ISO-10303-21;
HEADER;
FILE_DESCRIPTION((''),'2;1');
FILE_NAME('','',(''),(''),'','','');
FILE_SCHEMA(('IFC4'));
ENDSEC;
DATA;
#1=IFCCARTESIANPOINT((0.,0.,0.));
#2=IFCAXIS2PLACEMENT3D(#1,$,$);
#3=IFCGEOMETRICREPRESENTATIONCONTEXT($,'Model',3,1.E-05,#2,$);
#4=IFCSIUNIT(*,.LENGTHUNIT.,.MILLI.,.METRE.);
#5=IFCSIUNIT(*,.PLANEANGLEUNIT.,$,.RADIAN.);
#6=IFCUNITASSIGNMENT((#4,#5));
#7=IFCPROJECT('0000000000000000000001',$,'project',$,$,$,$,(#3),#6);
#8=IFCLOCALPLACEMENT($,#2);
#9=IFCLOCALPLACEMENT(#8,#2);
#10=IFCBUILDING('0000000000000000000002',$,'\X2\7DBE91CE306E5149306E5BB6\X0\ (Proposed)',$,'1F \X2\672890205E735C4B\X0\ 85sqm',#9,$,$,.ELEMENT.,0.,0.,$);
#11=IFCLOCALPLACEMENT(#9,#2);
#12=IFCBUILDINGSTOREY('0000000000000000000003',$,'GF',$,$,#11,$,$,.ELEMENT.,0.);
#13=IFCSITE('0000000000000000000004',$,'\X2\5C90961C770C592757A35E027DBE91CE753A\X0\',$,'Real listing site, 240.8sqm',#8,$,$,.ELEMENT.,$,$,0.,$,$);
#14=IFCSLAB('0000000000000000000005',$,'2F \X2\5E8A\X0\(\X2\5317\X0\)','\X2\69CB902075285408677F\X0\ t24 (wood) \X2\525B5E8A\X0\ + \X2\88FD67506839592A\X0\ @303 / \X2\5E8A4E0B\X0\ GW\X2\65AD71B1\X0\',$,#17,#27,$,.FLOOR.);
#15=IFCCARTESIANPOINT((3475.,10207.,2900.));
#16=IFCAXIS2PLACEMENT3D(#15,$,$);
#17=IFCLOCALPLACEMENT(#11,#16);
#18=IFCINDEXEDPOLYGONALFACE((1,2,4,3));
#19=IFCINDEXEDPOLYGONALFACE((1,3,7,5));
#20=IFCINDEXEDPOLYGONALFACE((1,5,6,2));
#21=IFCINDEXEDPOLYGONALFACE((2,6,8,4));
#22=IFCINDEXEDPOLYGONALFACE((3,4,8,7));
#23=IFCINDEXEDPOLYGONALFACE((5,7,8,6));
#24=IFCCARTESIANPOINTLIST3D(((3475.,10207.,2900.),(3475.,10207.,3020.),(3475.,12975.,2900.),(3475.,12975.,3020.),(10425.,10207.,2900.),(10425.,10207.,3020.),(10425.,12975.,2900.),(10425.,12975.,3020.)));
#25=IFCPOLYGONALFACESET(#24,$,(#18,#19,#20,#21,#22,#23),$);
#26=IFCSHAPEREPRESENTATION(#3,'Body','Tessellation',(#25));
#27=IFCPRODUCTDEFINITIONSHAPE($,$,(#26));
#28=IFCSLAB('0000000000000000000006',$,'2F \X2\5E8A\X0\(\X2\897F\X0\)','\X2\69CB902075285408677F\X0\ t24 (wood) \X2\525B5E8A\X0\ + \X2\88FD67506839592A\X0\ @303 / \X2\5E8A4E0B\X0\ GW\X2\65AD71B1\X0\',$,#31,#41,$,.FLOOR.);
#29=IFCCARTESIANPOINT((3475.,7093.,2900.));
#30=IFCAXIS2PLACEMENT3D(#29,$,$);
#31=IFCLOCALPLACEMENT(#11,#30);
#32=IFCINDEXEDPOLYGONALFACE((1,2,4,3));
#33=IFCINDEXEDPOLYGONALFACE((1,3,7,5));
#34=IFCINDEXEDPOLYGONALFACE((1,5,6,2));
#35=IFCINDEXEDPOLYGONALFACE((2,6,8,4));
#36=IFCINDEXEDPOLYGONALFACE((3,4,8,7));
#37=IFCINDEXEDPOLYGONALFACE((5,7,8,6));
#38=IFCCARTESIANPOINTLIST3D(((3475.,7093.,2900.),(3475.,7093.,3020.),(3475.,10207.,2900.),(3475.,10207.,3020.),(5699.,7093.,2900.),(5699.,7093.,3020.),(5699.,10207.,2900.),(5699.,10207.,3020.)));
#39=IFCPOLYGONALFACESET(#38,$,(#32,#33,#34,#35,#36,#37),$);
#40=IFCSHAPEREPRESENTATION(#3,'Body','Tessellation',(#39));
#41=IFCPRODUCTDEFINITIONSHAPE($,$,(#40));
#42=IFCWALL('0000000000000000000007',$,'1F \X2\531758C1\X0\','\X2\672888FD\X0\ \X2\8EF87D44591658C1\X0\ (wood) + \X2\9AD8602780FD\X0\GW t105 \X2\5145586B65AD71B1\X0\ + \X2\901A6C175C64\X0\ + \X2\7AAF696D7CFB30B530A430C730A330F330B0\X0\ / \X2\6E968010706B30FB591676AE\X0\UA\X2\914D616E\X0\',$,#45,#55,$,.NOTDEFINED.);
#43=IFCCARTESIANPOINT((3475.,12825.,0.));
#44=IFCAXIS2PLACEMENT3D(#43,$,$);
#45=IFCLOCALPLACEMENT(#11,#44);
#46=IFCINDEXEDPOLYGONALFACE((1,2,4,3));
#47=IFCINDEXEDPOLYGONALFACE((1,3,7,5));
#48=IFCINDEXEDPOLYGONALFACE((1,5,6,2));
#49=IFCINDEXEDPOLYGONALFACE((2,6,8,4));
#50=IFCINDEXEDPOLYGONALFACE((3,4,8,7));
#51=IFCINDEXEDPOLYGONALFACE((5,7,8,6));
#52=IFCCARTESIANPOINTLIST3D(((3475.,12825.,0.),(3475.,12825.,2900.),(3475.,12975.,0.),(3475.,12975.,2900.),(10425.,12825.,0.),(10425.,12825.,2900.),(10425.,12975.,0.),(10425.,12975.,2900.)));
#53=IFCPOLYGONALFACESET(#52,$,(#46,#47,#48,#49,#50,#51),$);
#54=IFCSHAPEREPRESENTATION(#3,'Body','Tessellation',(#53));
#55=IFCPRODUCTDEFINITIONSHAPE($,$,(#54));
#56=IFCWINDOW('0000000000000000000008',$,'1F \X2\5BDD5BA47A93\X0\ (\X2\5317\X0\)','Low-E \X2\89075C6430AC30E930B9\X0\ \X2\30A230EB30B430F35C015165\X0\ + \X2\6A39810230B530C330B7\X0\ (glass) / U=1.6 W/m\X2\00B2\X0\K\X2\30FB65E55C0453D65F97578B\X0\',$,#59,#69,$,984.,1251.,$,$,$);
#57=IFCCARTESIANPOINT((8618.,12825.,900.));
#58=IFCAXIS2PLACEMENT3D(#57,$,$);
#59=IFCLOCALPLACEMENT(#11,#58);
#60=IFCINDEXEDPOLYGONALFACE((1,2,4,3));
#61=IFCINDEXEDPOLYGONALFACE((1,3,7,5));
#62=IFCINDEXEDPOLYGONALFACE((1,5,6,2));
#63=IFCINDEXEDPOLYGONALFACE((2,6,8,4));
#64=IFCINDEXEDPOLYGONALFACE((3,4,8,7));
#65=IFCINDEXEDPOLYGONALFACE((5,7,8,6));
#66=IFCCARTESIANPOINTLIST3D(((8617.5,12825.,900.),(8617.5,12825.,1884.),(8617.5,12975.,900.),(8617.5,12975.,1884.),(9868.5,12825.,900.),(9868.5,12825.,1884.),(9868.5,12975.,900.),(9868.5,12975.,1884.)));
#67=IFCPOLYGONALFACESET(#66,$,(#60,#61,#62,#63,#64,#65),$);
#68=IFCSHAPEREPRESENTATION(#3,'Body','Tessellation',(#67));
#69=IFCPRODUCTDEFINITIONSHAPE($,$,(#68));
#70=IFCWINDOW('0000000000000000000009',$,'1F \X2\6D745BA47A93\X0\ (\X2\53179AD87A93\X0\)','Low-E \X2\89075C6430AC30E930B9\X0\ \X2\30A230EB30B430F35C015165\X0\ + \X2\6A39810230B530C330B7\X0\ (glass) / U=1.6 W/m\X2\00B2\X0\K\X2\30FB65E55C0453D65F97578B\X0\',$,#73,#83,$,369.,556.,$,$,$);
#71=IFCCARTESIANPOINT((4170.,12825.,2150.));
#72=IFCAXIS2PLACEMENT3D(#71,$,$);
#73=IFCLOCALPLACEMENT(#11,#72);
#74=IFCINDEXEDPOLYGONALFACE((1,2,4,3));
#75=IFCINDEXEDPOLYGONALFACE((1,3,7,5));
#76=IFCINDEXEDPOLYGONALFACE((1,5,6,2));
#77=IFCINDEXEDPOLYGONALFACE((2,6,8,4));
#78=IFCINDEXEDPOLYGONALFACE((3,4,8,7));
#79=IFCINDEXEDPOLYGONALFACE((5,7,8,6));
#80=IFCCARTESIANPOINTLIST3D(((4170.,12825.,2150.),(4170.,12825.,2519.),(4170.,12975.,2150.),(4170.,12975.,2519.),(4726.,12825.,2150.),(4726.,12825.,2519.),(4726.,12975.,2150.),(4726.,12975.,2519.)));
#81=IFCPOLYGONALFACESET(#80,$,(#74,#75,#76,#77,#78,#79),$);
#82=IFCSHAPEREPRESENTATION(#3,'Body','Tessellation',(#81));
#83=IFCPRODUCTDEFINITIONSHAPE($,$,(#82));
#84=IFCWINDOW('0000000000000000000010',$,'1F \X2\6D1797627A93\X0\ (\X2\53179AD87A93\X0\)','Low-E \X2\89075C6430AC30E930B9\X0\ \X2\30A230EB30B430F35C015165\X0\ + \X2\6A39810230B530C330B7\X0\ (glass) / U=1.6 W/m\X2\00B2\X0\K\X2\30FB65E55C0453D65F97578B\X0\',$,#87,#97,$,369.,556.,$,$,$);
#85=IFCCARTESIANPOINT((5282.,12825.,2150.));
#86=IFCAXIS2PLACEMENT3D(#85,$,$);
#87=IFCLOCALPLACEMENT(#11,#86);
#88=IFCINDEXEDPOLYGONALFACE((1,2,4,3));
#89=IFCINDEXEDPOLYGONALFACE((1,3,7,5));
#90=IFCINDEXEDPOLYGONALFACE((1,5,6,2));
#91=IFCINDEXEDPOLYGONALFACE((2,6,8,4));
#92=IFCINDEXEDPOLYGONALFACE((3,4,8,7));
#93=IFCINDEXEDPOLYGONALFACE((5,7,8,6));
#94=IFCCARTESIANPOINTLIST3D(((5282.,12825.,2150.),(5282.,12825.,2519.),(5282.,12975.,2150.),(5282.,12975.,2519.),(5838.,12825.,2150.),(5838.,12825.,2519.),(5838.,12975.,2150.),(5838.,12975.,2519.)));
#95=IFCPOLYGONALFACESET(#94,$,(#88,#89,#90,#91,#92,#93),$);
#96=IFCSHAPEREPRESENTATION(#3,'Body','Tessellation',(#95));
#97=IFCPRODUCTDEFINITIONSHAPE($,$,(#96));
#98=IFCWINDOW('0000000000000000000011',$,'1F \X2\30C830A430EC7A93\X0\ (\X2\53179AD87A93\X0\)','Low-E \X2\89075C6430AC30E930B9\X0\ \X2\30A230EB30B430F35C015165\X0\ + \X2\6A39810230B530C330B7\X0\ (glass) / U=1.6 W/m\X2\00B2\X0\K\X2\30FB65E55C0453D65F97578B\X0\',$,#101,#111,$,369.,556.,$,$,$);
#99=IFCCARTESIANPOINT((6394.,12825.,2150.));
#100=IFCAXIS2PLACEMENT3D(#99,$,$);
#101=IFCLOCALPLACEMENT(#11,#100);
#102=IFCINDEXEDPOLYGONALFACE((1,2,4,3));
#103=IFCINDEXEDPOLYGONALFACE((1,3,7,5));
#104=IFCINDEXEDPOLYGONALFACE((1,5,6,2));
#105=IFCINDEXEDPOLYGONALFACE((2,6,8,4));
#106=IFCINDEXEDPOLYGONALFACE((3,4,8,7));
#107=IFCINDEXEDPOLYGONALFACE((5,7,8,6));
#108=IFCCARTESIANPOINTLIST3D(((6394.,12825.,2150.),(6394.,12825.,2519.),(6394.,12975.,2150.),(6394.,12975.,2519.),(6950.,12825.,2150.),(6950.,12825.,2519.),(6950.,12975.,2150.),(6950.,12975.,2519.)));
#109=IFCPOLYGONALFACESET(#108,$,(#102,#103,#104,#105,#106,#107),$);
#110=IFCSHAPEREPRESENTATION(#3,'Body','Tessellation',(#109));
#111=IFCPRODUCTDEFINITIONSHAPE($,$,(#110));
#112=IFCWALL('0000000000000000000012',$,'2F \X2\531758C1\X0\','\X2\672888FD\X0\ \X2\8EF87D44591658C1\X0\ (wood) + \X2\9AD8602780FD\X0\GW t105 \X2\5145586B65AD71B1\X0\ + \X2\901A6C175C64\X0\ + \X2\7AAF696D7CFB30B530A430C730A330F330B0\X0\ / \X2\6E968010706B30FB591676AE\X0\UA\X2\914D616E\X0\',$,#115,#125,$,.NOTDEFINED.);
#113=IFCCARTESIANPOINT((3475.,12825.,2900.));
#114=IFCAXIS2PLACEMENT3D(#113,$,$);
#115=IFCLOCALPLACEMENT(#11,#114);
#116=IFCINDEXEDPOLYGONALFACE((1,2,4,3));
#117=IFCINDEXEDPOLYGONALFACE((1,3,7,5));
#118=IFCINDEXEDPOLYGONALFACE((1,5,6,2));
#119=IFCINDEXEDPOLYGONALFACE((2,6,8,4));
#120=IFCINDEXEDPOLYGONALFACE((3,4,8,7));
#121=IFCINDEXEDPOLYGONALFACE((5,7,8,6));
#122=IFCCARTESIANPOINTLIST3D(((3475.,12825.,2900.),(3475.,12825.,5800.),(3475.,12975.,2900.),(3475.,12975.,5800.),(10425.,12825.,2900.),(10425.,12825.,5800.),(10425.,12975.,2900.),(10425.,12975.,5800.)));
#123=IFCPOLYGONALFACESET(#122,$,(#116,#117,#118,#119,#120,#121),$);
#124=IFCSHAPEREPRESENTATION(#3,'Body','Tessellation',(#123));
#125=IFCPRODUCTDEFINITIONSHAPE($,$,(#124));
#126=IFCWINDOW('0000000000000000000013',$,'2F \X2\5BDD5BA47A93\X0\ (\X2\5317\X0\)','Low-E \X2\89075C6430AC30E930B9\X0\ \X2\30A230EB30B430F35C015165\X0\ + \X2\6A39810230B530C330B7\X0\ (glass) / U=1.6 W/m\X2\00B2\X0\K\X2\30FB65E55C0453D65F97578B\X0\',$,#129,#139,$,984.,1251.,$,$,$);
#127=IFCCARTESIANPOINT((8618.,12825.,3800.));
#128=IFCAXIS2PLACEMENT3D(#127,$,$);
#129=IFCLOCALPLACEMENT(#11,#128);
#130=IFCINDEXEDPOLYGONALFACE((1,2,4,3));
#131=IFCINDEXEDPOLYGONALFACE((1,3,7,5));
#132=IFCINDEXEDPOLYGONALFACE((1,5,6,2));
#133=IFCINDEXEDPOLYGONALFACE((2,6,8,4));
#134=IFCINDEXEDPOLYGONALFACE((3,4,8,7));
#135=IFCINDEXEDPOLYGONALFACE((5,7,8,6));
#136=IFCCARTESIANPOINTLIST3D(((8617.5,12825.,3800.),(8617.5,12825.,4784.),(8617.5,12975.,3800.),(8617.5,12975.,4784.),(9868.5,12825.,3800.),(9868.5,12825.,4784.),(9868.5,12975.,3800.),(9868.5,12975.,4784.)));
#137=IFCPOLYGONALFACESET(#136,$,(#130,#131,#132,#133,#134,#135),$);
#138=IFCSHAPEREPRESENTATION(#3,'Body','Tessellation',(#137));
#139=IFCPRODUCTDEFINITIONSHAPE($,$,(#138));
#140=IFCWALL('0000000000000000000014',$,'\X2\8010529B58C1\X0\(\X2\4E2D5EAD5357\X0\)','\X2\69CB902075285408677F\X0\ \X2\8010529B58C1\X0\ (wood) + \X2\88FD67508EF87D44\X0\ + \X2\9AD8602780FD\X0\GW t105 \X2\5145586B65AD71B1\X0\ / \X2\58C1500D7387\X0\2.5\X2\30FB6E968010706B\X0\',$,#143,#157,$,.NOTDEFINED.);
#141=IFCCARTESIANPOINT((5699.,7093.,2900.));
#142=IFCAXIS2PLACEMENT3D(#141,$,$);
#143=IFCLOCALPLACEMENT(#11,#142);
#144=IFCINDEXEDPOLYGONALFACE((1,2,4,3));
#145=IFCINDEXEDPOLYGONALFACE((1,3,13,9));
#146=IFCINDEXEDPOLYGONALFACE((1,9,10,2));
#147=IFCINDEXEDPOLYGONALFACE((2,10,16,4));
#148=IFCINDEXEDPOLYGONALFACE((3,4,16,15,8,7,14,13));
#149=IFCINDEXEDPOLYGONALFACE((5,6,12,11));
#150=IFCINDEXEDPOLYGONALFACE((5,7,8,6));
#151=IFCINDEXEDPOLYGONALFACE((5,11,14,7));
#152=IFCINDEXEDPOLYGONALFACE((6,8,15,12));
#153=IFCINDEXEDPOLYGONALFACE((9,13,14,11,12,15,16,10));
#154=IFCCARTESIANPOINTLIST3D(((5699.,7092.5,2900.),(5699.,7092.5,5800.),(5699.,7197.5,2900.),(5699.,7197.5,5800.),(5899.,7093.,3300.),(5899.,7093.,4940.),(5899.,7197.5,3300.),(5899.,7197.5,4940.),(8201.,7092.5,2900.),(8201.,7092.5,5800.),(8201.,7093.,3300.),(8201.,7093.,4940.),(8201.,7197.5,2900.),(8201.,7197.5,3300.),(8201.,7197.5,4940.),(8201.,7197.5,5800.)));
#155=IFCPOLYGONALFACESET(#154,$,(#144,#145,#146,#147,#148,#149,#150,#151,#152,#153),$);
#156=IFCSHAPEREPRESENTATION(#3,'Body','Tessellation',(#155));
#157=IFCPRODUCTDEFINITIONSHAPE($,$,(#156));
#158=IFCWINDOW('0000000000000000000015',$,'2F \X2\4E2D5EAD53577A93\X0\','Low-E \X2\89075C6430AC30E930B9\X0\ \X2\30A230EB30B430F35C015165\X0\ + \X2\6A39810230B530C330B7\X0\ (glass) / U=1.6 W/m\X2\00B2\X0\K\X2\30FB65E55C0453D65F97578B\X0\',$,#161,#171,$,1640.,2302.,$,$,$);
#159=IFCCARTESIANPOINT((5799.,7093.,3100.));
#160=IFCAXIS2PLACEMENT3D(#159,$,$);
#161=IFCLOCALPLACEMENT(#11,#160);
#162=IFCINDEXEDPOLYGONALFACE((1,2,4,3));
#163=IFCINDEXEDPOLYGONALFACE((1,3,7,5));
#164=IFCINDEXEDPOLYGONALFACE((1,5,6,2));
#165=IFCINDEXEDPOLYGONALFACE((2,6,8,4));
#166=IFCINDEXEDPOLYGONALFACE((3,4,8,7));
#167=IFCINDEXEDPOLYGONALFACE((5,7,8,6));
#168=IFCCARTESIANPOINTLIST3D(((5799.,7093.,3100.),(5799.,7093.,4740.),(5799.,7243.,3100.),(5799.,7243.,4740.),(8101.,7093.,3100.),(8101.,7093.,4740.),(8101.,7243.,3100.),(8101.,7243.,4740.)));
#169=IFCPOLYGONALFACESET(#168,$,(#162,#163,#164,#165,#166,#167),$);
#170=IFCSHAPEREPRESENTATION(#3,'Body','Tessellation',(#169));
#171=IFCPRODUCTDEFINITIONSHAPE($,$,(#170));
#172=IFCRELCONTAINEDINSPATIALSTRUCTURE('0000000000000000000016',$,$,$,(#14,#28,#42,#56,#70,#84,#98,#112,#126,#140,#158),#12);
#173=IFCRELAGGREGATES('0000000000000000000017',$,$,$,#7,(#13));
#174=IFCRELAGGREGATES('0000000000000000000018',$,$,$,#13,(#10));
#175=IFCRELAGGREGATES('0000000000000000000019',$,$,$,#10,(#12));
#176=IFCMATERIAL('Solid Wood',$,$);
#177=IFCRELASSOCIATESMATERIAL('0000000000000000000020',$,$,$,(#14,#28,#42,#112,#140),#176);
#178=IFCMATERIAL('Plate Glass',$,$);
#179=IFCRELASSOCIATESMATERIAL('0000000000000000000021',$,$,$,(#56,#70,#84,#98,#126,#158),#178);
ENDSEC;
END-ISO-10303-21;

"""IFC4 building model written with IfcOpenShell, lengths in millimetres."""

from ifc_helpers import new_model, si_unit, frame, frame_2d, origin, place, context, project, spatial, rectangle, extrude, material, element, fill, save


model = new_model("IFC4")

# Units and contexts
model_context = context("Model", 3, precision=1e-05, world=origin())
ifc_project = project(units=[si_unit("LENGTHUNIT", "METRE", prefix="MILLI"), si_unit("PLANEANGLEUNIT", "RADIAN")], contexts=[model_context])

# Site, building, storey
site_placement = place(None, origin())
site = spatial("IfcSite", under=ifc_project, at=site_placement, Name="岐阜県大垣市綾野町", ObjectType="Real listing site, 240.8sqm", CompositionType="ELEMENT", RefElevation=0.0)
building_placement = place(site_placement, origin())
building = spatial("IfcBuilding", under=site, at=building_placement, Name="綾野の光の家 (Proposed)", ObjectType="1F 木造平屋 85sqm", CompositionType="ELEMENT", ElevationOfRefHeight=0.0, ElevationOfTerrain=0.0)
storey_placement = place(building_placement, origin())
storey = spatial("IfcBuildingStorey", under=building, at=storey_placement, Name="GF", CompositionType="ELEMENT", Elevation=0.0)

# Slabs
ifc_material_1 = material(Name="Solid Wood")
slab_1_placement = place(storey_placement, frame((3475.0, 10207.0, 2900.0)))
element("IfcSlab", 1, at=slab_1_placement, inside=storey, material=ifc_material_1, Name="2F 床(北)", Description="構造用合板 t24 (wood) 剛床 + 製材根太 @303 / 床下 GW断熱", PredefinedType="FLOOR", context=model_context, shape_type="SweptSolid", body=[
    extrude(rectangle(XDim=6950.0, YDim=2768.0, at=frame_2d((3475.0, 1384.0))), frame((3475.0, 10207.0, 2900.0)), (0.0, 0.0, 1.0), 120.0),
])
slab_2_placement = place(storey_placement, frame((3475.0, 7093.0, 2900.0)))
element("IfcSlab", 2, at=slab_2_placement, inside=storey, material=ifc_material_1, Name="2F 床(西)", Description="構造用合板 t24 (wood) 剛床 + 製材根太 @303 / 床下 GW断熱", PredefinedType="FLOOR", context=model_context, shape_type="SweptSolid", body=[
    extrude(rectangle(XDim=2224.0, YDim=3114.0, at=frame_2d((1112.0, 1557.0))), frame((3475.0, 7093.0, 2900.0)), (0.0, 0.0, 1.0), 120.0),
])

# Wall, openings, windows
wall_1_placement = place(storey_placement, frame((3475.0, 12825.0, 0.0)))
wall_1 = element("IfcWall", 3, at=wall_1_placement, inside=storey, material=ifc_material_1, Name="1F 北壁", Description="木製 軸組外壁 (wood) + 高性能GW t105 充填断熱 + 通気層 + 窯業系サイディング / 準耐火・外皮UA配慮", PredefinedType="NOTDEFINED", context=model_context, shape_type="SweptSolid", body=[
    extrude(rectangle(XDim=6950.0, YDim=150.0, at=frame_2d((3475.0, 75.0))), frame((3475.0, 12825.0, 0.0)), (0.0, 0.0, 1.0), 2900.0),
])
opening_1_placement = place(storey_placement, frame((8618.0, 12825.0, 900.0)))
opening_1 = element("IfcOpeningElement", 4, at=opening_1_placement, cuts=wall_1, PredefinedType="NOTDEFINED", context=model_context, shape_type="SweptSolid", body=[
    extrude(rectangle(XDim=1251.0, YDim=150.0, at=frame_2d((625.0, 75.0))), frame((8618.0, 12825.0, 900.0)), (0.0, 0.0, 1.0), 984.0),
])
opening_2_placement = place(storey_placement, frame((4170.0, 12825.0, 2150.0)))
opening_2 = element("IfcOpeningElement", 5, at=opening_2_placement, cuts=wall_1, PredefinedType="NOTDEFINED", context=model_context, shape_type="SweptSolid", body=[
    extrude(rectangle(XDim=556.0, YDim=150.0, at=frame_2d((278.0, 75.0))), frame((4170.0, 12825.0, 2150.0)), (0.0, 0.0, 1.0), 369.0),
])
opening_3_placement = place(storey_placement, frame((5282.0, 12825.0, 2150.0)))
opening_3 = element("IfcOpeningElement", 6, at=opening_3_placement, cuts=wall_1, PredefinedType="NOTDEFINED", context=model_context, shape_type="SweptSolid", body=[
    extrude(rectangle(XDim=556.0, YDim=150.0, at=frame_2d((278.0, 75.0))), frame((5282.0, 12825.0, 2150.0)), (0.0, 0.0, 1.0), 369.0),
])
opening_4_placement = place(storey_placement, frame((6394.0, 12825.0, 2150.0)))
opening_4 = element("IfcOpeningElement", 7, at=opening_4_placement, cuts=wall_1, PredefinedType="NOTDEFINED", context=model_context, shape_type="SweptSolid", body=[
    extrude(rectangle(XDim=556.0, YDim=150.0, at=frame_2d((278.0, 75.0))), frame((6394.0, 12825.0, 2150.0)), (0.0, 0.0, 1.0), 369.0),
])
ifc_material_2 = material(Name="Plate Glass")
window_1_placement = place(storey_placement, frame((8618.0, 12825.0, 900.0)))
window_1 = element("IfcWindow", 8, at=window_1_placement, inside=storey, material=ifc_material_2, Name="1F 寝室窓 (北)", Description="Low-E 複層ガラス アルゴン封入 + 樹脂サッシ (glass) / U=1.6 W/m²K・日射取得型", OverallHeight=984.0, OverallWidth=1251.0, context=model_context, shape_type="SweptSolid", body=[
    extrude(rectangle(XDim=1251.0, YDim=150.0, at=frame_2d((625.0, 75.0))), frame((8618.0, 12825.0, 900.0)), (0.0, 0.0, 1.0), 984.0),
])
fill(opening_1, window_1)
window_2_placement = place(storey_placement, frame((4170.0, 12825.0, 2150.0)))
window_2 = element("IfcWindow", 9, at=window_2_placement, inside=storey, material=ifc_material_2, Name="1F 浴室窓 (北高窓)", Description="Low-E 複層ガラス アルゴン封入 + 樹脂サッシ (glass) / U=1.6 W/m²K・日射取得型", OverallHeight=369.0, OverallWidth=556.0, context=model_context, shape_type="SweptSolid", body=[
    extrude(rectangle(XDim=556.0, YDim=150.0, at=frame_2d((278.0, 75.0))), frame((4170.0, 12825.0, 2150.0)), (0.0, 0.0, 1.0), 369.0),
])
fill(opening_2, window_2)
window_3_placement = place(storey_placement, frame((5282.0, 12825.0, 2150.0)))
window_3 = element("IfcWindow", 10, at=window_3_placement, inside=storey, material=ifc_material_2, Name="1F 洗面窓 (北高窓)", Description="Low-E 複層ガラス アルゴン封入 + 樹脂サッシ (glass) / U=1.6 W/m²K・日射取得型", OverallHeight=369.0, OverallWidth=556.0, context=model_context, shape_type="SweptSolid", body=[
    extrude(rectangle(XDim=556.0, YDim=150.0, at=frame_2d((278.0, 75.0))), frame((5282.0, 12825.0, 2150.0)), (0.0, 0.0, 1.0), 369.0),
])
fill(opening_3, window_3)
window_4_placement = place(storey_placement, frame((6394.0, 12825.0, 2150.0)))
window_4 = element("IfcWindow", 11, at=window_4_placement, inside=storey, material=ifc_material_2, Name="1F トイレ窓 (北高窓)", Description="Low-E 複層ガラス アルゴン封入 + 樹脂サッシ (glass) / U=1.6 W/m²K・日射取得型", OverallHeight=369.0, OverallWidth=556.0, context=model_context, shape_type="SweptSolid", body=[
    extrude(rectangle(XDim=556.0, YDim=150.0, at=frame_2d((278.0, 75.0))), frame((6394.0, 12825.0, 2150.0)), (0.0, 0.0, 1.0), 369.0),
])
fill(opening_4, window_4)

# Walls, openings, windows
wall_2_placement = place(storey_placement, frame((3475.0, 12825.0, 2900.0)))
wall_2 = element("IfcWall", 12, at=wall_2_placement, inside=storey, material=ifc_material_1, Name="2F 北壁", Description="木製 軸組外壁 (wood) + 高性能GW t105 充填断熱 + 通気層 + 窯業系サイディング / 準耐火・外皮UA配慮", PredefinedType="NOTDEFINED", context=model_context, shape_type="SweptSolid", body=[
    extrude(rectangle(XDim=6950.0, YDim=150.0, at=frame_2d((3475.0, 75.0))), frame((3475.0, 12825.0, 2900.0)), (0.0, 0.0, 1.0), 2900.0),
])
opening_5_placement = place(storey_placement, frame((8618.0, 12825.0, 3800.0)))
opening_5 = element("IfcOpeningElement", 13, at=opening_5_placement, cuts=wall_2, PredefinedType="NOTDEFINED", context=model_context, shape_type="SweptSolid", body=[
    extrude(rectangle(XDim=1251.0, YDim=150.0, at=frame_2d((625.0, 75.0))), frame((8618.0, 12825.0, 3800.0)), (0.0, 0.0, 1.0), 984.0),
])
window_5_placement = place(storey_placement, frame((8618.0, 12825.0, 3800.0)))
window_5 = element("IfcWindow", 14, at=window_5_placement, inside=storey, material=ifc_material_2, Name="2F 寝室窓 (北)", Description="Low-E 複層ガラス アルゴン封入 + 樹脂サッシ (glass) / U=1.6 W/m²K・日射取得型", OverallHeight=984.0, OverallWidth=1251.0, context=model_context, shape_type="SweptSolid", body=[
    extrude(rectangle(XDim=1251.0, YDim=150.0, at=frame_2d((625.0, 75.0))), frame((8618.0, 12825.0, 3800.0)), (0.0, 0.0, 1.0), 984.0),
])
fill(opening_5, window_5)
wall_3_placement = place(storey_placement, frame((5699.0, 7093.0, 2900.0)))
wall_3 = element("IfcWall", 15, at=wall_3_placement, inside=storey, material=ifc_material_1, Name="耐力壁(中庭南)", Description="構造用合板 耐力壁 (wood) + 製材軸組 + 高性能GW t105 充填断熱 / 壁倍率2.5・準耐火", PredefinedType="NOTDEFINED", context=model_context, shape_type="SweptSolid", body=[
    extrude(rectangle(XDim=2502.0, YDim=105.0, at=frame_2d((1251.0, 52.0))), frame((5699.0, 7093.0, 2900.0)), (0.0, 0.0, 1.0), 2900.0),
])
opening_6_placement = place(storey_placement, frame((5799.0, 7093.0, 3100.0)))
opening_6 = element("IfcOpeningElement", 16, at=opening_6_placement, cuts=wall_3, PredefinedType="NOTDEFINED", context=model_context, shape_type="SweptSolid", body=[
    extrude(rectangle(XDim=2302.0, YDim=150.0, at=frame_2d((1151.0, 75.0))), frame((5799.0, 7093.0, 3100.0)), (0.0, 0.0, 1.0), 1640.0),
])
window_6_placement = place(storey_placement, frame((5799.0, 7093.0, 3100.0)))
window_6 = element("IfcWindow", 17, at=window_6_placement, inside=storey, material=ifc_material_2, Name="2F 中庭南窓", Description="Low-E 複層ガラス アルゴン封入 + 樹脂サッシ (glass) / U=1.6 W/m²K・日射取得型", OverallHeight=1640.0, OverallWidth=2302.0, context=model_context, shape_type="SweptSolid", body=[
    extrude(rectangle(XDim=2302.0, YDim=150.0, at=frame_2d((1151.0, 75.0))), frame((5799.0, 7093.0, 3100.0)), (0.0, 0.0, 1.0), 1640.0),
])
fill(opening_6, window_6)

save(model, "model.ifc")
